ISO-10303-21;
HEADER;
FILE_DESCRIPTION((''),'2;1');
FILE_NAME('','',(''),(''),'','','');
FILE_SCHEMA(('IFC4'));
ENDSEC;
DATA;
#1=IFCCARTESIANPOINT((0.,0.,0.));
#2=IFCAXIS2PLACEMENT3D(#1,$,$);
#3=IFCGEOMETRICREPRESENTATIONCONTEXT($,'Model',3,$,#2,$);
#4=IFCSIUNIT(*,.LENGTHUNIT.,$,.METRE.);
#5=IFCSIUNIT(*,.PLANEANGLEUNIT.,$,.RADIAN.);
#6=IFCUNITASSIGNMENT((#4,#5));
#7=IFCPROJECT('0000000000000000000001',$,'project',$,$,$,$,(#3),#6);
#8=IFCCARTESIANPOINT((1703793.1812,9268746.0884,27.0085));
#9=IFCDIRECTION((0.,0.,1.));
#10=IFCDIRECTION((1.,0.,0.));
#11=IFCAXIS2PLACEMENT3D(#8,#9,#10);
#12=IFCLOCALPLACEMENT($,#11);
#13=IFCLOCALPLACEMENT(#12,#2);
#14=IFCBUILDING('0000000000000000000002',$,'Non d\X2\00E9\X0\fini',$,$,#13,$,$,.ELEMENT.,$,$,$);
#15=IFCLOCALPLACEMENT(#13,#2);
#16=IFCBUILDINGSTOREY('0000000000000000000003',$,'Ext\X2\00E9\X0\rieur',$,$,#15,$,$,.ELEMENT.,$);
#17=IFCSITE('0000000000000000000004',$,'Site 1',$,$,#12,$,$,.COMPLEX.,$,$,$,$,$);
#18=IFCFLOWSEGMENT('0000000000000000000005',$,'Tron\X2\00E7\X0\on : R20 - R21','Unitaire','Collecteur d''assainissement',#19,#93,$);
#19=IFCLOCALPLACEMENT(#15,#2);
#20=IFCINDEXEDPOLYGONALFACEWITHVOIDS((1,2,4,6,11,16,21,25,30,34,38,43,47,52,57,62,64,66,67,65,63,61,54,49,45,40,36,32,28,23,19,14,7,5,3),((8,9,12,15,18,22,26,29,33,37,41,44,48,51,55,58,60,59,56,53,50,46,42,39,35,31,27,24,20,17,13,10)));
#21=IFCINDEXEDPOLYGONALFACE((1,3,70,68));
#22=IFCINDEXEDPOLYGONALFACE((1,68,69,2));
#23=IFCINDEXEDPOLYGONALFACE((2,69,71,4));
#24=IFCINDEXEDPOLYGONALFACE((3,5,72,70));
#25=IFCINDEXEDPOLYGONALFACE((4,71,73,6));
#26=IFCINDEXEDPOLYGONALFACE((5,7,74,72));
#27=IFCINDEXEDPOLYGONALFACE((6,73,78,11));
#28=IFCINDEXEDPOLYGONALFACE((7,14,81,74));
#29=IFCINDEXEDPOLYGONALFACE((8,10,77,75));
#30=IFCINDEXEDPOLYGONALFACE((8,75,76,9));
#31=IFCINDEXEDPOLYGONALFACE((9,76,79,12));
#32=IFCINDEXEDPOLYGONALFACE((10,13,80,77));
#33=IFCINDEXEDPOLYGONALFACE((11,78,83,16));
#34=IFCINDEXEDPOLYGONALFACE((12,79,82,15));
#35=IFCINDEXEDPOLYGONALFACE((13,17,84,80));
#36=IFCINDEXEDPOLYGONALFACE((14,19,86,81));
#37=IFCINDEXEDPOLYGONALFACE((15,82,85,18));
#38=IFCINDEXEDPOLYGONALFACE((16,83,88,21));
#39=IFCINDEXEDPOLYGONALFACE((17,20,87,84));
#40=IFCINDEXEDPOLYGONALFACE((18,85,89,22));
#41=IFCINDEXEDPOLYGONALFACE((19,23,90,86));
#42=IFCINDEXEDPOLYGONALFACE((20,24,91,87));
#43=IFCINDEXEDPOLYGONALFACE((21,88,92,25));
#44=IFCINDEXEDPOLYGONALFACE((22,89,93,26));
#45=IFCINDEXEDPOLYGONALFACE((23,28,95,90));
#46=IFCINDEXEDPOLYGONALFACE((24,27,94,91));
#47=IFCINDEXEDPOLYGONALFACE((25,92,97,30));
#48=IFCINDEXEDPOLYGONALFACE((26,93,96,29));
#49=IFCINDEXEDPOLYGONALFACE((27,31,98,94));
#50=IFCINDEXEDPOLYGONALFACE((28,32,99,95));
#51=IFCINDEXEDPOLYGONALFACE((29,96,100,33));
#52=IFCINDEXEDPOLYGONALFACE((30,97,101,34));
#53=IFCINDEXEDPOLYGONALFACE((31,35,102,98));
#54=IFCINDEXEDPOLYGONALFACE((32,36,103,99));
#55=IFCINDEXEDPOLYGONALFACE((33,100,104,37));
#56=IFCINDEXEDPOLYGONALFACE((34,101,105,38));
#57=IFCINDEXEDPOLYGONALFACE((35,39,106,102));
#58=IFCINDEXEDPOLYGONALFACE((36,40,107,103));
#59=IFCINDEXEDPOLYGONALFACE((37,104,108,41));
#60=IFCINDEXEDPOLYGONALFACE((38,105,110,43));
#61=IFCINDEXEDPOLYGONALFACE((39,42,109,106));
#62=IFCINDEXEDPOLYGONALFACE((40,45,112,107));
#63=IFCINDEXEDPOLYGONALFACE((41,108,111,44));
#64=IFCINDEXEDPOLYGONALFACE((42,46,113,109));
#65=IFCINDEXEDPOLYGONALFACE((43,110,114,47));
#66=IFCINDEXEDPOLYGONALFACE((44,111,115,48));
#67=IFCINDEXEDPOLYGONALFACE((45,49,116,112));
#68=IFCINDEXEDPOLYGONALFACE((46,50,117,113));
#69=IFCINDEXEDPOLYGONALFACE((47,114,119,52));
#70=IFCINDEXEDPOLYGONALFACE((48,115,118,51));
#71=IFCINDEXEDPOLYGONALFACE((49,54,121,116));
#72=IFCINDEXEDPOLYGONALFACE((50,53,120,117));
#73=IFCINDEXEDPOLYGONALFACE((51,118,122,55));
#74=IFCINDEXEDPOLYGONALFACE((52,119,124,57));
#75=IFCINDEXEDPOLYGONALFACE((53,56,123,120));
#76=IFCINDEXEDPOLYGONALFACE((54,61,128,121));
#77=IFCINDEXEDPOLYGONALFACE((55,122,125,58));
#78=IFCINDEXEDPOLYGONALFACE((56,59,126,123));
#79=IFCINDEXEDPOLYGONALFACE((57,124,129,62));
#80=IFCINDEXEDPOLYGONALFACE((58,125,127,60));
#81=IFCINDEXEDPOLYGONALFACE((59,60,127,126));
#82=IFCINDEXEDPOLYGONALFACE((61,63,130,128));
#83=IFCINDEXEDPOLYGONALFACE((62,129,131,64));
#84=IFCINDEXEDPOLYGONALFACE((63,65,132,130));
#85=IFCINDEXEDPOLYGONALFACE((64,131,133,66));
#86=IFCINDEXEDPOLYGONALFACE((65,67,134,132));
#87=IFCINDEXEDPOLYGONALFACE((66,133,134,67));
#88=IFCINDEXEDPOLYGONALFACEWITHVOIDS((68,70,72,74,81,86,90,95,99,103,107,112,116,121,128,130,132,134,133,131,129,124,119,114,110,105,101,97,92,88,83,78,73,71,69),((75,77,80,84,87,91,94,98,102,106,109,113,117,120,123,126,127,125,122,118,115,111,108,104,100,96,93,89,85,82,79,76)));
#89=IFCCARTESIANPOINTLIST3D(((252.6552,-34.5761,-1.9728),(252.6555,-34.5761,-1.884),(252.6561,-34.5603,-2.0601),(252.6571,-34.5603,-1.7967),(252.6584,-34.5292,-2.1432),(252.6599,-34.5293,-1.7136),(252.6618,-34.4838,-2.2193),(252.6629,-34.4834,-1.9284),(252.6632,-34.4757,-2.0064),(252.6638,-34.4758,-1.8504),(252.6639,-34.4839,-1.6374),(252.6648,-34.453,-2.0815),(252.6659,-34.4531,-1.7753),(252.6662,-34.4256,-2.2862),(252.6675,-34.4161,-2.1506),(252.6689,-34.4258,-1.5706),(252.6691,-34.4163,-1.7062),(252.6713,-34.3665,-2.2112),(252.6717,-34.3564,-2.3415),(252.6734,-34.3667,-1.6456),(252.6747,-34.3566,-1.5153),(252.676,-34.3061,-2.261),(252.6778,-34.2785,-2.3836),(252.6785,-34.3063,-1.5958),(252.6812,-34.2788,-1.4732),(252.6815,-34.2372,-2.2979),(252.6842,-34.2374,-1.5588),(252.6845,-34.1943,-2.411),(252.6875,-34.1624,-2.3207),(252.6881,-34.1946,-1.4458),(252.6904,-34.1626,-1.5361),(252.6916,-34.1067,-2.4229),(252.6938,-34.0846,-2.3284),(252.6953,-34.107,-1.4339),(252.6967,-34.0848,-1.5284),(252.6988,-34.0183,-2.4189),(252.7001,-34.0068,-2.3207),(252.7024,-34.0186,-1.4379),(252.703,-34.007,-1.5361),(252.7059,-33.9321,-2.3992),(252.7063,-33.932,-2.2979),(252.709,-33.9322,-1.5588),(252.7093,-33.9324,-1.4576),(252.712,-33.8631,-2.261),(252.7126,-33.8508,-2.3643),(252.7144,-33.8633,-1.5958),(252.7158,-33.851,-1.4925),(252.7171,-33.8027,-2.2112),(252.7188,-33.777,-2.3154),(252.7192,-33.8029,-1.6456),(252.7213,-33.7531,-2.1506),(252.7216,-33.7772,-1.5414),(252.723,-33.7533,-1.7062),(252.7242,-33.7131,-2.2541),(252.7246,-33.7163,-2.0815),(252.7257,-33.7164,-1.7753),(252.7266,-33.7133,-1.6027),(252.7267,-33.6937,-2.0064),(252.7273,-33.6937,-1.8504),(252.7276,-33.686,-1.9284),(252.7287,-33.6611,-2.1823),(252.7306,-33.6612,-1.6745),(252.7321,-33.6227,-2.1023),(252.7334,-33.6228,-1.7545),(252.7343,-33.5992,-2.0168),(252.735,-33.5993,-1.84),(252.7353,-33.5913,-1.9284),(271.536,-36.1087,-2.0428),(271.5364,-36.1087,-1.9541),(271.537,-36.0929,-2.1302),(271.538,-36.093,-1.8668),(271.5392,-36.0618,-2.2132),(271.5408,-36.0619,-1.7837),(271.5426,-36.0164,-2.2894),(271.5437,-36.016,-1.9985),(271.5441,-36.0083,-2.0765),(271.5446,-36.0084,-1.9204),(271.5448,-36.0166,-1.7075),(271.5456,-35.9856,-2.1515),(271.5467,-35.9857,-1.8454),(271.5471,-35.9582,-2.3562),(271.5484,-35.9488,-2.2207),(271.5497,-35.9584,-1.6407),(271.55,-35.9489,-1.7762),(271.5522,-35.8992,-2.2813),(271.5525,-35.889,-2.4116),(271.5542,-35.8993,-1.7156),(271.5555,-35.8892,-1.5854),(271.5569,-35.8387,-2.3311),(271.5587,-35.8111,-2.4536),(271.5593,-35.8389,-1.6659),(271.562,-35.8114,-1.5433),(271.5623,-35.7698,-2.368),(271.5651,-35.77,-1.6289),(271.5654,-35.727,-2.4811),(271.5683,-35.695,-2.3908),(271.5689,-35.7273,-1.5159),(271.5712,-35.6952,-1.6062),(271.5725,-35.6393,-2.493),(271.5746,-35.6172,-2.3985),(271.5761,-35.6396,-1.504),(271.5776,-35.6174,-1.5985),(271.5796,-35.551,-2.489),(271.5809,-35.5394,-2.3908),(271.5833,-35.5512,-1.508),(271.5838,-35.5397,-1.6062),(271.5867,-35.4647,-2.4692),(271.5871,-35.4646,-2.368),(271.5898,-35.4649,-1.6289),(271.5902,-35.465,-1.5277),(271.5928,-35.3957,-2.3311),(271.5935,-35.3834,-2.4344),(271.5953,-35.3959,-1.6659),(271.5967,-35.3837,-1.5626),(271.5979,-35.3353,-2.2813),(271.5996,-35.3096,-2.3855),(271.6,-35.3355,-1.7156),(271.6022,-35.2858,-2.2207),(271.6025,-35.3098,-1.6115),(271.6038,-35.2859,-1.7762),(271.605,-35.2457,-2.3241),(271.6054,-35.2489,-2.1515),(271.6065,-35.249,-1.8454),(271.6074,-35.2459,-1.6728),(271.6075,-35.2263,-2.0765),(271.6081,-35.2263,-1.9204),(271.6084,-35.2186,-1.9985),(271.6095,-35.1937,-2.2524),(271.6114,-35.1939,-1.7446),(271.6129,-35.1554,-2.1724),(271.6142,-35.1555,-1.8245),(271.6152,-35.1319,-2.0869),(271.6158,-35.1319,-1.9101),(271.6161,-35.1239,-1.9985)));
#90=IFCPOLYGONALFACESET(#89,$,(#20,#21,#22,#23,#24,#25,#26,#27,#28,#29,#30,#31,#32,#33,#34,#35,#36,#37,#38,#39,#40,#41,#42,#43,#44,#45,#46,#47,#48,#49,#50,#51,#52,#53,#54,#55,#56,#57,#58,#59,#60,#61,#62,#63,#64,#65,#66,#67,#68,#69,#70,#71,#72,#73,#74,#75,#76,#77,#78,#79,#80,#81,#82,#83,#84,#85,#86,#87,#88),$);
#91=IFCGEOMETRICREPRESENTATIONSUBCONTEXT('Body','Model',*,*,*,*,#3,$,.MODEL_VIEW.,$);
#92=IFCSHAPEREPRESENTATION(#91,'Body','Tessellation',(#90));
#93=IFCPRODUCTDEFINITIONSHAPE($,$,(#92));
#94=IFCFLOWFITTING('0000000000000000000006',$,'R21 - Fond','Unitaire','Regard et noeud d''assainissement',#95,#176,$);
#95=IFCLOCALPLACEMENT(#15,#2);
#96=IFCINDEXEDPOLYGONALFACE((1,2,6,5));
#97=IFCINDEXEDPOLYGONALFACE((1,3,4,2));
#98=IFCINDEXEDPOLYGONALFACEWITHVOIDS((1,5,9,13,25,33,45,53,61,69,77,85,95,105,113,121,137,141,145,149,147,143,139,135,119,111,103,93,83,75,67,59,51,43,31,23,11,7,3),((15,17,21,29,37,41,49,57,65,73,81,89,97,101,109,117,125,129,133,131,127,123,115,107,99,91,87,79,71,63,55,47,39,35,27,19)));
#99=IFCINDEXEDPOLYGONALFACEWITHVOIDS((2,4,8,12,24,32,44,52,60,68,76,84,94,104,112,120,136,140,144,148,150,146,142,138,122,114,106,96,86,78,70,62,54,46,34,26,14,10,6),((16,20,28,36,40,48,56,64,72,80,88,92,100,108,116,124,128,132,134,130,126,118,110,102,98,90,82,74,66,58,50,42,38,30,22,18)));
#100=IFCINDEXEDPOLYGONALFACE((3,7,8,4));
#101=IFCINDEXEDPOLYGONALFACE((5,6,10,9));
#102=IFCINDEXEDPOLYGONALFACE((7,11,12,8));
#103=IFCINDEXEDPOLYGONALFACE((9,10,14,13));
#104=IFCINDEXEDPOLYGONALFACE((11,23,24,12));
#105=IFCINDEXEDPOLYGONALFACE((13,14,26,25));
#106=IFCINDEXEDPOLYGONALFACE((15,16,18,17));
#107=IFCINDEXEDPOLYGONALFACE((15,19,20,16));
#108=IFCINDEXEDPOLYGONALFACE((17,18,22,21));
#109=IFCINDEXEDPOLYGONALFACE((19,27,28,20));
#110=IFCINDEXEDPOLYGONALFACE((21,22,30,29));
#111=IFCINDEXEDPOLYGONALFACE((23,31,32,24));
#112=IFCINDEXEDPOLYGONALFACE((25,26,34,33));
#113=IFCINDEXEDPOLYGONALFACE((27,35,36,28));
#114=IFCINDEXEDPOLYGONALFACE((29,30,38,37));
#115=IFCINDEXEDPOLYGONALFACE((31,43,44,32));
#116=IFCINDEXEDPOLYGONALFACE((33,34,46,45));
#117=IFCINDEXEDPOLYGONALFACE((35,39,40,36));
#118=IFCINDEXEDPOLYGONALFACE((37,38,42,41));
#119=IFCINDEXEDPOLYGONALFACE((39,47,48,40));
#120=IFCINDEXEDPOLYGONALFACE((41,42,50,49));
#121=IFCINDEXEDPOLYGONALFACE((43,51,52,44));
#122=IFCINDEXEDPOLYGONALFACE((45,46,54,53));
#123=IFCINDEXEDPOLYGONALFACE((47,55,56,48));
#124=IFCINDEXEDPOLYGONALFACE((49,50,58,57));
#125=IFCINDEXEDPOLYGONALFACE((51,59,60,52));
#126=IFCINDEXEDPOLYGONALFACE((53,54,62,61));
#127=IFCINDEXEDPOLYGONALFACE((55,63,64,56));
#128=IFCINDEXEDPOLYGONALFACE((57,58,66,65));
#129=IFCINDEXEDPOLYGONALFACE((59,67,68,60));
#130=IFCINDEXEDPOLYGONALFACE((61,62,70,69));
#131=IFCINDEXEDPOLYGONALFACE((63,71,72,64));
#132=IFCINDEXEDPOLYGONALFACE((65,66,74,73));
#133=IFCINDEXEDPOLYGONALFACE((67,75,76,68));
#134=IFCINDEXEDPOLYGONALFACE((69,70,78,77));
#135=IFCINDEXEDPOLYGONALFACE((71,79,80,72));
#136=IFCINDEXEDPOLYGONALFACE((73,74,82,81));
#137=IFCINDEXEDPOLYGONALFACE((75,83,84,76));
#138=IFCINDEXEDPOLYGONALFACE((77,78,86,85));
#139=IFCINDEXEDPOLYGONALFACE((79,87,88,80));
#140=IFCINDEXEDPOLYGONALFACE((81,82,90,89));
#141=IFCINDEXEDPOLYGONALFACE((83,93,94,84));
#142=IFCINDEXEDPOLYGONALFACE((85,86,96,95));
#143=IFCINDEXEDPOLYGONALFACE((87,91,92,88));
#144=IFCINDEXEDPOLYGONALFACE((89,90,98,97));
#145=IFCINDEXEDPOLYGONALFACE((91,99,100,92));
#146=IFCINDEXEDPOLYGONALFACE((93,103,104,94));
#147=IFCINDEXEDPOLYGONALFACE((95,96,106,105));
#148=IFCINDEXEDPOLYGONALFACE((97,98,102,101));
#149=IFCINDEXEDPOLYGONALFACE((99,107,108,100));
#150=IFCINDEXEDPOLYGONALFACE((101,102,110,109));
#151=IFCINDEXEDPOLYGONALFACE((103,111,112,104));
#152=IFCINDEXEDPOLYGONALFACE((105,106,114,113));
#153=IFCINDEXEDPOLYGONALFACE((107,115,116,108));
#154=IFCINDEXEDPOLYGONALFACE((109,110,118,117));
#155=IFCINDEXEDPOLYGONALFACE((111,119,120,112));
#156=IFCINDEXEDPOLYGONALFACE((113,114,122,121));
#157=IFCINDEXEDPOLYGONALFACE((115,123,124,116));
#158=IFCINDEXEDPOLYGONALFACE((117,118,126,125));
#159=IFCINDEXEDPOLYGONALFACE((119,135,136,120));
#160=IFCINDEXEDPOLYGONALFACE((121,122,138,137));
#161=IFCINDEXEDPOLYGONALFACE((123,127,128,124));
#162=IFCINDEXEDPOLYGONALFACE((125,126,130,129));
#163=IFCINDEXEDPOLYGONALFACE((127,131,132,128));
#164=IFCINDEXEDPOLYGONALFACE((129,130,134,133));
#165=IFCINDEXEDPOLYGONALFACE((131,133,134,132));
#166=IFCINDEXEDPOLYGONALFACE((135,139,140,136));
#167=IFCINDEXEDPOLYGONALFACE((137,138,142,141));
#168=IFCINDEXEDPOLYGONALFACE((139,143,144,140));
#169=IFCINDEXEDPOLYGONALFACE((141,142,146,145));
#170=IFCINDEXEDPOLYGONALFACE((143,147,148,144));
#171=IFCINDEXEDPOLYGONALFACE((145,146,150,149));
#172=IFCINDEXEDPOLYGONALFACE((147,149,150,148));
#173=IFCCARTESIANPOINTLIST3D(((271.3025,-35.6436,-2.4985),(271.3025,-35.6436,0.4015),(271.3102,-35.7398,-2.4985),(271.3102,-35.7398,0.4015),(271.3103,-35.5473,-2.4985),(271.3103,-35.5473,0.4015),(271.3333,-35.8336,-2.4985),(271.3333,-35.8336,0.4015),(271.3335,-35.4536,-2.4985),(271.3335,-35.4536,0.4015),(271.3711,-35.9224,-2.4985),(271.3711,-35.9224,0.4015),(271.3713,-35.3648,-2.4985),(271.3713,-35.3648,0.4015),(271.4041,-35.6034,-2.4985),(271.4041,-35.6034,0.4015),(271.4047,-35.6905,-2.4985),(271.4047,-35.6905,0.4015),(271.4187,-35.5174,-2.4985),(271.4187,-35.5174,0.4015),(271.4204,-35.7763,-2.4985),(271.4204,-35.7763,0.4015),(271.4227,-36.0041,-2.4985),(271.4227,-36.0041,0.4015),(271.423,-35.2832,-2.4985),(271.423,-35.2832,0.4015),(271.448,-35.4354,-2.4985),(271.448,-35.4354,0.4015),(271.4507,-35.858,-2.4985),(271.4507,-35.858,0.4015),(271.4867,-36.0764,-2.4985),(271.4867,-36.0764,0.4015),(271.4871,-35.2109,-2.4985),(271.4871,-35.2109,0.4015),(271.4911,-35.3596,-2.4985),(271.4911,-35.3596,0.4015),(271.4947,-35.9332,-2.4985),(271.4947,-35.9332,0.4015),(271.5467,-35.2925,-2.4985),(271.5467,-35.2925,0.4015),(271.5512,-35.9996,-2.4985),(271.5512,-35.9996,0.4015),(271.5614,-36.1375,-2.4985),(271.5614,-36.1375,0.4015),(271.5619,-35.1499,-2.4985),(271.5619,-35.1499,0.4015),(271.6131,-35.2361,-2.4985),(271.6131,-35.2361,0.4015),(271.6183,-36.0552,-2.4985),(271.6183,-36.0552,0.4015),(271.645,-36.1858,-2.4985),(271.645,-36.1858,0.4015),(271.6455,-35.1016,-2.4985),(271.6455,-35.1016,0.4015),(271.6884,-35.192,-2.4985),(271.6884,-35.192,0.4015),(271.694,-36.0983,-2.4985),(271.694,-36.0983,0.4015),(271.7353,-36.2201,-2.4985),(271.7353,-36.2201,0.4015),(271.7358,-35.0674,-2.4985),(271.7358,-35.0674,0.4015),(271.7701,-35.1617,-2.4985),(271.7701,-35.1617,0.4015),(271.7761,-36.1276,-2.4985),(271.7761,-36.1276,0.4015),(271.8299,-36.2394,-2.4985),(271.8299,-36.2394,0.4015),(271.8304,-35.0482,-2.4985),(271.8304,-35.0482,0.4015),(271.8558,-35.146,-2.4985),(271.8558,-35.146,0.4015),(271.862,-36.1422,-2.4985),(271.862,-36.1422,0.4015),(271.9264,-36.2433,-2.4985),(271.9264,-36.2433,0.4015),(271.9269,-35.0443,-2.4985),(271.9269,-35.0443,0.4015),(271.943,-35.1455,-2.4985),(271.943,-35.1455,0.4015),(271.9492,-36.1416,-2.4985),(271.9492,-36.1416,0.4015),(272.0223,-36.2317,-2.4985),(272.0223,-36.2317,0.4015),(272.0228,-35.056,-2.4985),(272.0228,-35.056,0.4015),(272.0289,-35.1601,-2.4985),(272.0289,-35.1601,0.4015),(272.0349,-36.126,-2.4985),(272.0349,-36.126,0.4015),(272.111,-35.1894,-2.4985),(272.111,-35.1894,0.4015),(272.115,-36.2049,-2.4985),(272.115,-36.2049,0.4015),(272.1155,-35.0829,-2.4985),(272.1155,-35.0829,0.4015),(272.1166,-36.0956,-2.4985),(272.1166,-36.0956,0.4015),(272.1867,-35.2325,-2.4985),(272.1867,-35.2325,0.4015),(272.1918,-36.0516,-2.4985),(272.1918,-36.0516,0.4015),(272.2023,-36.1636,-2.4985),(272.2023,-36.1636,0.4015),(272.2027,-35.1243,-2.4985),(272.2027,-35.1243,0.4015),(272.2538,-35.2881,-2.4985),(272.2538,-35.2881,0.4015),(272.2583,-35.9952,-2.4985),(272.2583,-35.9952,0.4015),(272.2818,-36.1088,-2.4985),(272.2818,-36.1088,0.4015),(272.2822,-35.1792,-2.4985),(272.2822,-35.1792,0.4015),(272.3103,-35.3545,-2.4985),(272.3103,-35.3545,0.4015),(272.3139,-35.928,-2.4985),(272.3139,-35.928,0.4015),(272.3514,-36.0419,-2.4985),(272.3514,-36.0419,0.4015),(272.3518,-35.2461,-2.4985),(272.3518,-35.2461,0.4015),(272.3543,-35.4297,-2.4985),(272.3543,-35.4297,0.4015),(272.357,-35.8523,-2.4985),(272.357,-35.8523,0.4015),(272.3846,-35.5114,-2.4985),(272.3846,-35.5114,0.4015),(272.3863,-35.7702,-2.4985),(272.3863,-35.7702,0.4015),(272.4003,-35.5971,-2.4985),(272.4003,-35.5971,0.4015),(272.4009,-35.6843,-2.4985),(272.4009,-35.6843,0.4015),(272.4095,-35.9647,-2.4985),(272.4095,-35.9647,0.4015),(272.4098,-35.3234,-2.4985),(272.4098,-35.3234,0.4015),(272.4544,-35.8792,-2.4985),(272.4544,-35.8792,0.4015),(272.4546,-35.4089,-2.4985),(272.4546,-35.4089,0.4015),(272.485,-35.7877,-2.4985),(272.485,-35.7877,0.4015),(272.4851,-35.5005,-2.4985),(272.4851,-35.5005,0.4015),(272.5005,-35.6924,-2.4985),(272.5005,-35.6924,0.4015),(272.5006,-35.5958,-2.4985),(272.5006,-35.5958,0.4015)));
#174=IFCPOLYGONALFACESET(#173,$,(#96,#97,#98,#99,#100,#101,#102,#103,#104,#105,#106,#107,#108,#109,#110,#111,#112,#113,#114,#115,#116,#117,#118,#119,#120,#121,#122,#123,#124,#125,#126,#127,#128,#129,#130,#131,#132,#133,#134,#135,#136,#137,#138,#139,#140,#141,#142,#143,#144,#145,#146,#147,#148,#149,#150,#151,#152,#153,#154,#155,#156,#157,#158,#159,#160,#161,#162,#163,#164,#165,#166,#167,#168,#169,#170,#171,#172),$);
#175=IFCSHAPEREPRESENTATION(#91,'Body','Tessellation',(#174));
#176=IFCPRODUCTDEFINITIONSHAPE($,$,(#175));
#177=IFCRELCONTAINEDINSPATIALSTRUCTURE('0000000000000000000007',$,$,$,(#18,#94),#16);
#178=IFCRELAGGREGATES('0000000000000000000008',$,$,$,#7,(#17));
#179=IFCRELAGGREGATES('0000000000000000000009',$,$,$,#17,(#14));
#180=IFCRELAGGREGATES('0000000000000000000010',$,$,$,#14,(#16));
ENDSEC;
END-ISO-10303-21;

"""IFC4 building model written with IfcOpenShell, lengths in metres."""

from ifc_helpers import new_model, si_unit, frame, origin, origin_2d, place, context, subcontext, project, spatial, hollow_circle, extrude, element, save


model = new_model("IFC4")

# Units and contexts
model_context = context("Model", 3, world=origin())
body_context = subcontext(model_context, "Body", "Model", "MODEL_VIEW")
ifc_project = project(units=[si_unit("LENGTHUNIT", "METRE"), si_unit("PLANEANGLEUNIT", "RADIAN")], contexts=[model_context])

# Site, building, storey
site_placement = place(None, frame((1703793.1812, 9268746.0884, 27.0085), z_axis=(0.0, 0.0, 1.0), x_axis=(1.0, 0.0, 0.0)))
site = spatial("IfcSite", under=ifc_project, at=site_placement, Name="Site 1", CompositionType="COMPLEX")
building_placement = place(site_placement, origin())
building = spatial("IfcBuilding", under=site, at=building_placement, Name="Non défini", CompositionType="ELEMENT")
storey_placement = place(building_placement, origin())
storey = spatial("IfcBuildingStorey", under=building, at=storey_placement, Name="Extérieur", CompositionType="ELEMENT")

# Flow segment
flow_segment_1_placement = place(storey_placement, origin())
element("IfcFlowSegment", 1, at=flow_segment_1_placement, inside=storey, Name="Tronçon : R20 - R21", Description="Unitaire", ObjectType="Collecteur d'assainissement", context=body_context, shape_type="SweptSolid", body=[
    extrude(hollow_circle(Radius=0.495, WallThickness=0.095, at=origin_2d()), frame((252.6952, -34.0847, -1.9284), z_axis=(0.996715, -0.080907, -0.003699), x_axis=(0.080907, 0.996722, 0.0)), (0.0, 0.0, 1.0), 18.9431),
])

# Flow fitting
flow_fitting_1_placement = place(storey_placement, origin())
element("IfcFlowFitting", 2, at=flow_fitting_1_placement, inside=storey, Name="R21 - Fond", Description="Unitaire", ObjectType="Regard et noeud d'assainissement", context=body_context, shape_type="SweptSolid", body=[
    extrude(hollow_circle(Radius=0.6, WallThickness=0.1, at=origin_2d()), frame((271.9025, -35.6438, -2.4985), z_axis=(0.0, 0.0, 1.0), x_axis=(0.996722, -0.080907, 0.0)), (0.0, 0.0, 1.0), 2.9),
])

save(model, "model.ifc")
